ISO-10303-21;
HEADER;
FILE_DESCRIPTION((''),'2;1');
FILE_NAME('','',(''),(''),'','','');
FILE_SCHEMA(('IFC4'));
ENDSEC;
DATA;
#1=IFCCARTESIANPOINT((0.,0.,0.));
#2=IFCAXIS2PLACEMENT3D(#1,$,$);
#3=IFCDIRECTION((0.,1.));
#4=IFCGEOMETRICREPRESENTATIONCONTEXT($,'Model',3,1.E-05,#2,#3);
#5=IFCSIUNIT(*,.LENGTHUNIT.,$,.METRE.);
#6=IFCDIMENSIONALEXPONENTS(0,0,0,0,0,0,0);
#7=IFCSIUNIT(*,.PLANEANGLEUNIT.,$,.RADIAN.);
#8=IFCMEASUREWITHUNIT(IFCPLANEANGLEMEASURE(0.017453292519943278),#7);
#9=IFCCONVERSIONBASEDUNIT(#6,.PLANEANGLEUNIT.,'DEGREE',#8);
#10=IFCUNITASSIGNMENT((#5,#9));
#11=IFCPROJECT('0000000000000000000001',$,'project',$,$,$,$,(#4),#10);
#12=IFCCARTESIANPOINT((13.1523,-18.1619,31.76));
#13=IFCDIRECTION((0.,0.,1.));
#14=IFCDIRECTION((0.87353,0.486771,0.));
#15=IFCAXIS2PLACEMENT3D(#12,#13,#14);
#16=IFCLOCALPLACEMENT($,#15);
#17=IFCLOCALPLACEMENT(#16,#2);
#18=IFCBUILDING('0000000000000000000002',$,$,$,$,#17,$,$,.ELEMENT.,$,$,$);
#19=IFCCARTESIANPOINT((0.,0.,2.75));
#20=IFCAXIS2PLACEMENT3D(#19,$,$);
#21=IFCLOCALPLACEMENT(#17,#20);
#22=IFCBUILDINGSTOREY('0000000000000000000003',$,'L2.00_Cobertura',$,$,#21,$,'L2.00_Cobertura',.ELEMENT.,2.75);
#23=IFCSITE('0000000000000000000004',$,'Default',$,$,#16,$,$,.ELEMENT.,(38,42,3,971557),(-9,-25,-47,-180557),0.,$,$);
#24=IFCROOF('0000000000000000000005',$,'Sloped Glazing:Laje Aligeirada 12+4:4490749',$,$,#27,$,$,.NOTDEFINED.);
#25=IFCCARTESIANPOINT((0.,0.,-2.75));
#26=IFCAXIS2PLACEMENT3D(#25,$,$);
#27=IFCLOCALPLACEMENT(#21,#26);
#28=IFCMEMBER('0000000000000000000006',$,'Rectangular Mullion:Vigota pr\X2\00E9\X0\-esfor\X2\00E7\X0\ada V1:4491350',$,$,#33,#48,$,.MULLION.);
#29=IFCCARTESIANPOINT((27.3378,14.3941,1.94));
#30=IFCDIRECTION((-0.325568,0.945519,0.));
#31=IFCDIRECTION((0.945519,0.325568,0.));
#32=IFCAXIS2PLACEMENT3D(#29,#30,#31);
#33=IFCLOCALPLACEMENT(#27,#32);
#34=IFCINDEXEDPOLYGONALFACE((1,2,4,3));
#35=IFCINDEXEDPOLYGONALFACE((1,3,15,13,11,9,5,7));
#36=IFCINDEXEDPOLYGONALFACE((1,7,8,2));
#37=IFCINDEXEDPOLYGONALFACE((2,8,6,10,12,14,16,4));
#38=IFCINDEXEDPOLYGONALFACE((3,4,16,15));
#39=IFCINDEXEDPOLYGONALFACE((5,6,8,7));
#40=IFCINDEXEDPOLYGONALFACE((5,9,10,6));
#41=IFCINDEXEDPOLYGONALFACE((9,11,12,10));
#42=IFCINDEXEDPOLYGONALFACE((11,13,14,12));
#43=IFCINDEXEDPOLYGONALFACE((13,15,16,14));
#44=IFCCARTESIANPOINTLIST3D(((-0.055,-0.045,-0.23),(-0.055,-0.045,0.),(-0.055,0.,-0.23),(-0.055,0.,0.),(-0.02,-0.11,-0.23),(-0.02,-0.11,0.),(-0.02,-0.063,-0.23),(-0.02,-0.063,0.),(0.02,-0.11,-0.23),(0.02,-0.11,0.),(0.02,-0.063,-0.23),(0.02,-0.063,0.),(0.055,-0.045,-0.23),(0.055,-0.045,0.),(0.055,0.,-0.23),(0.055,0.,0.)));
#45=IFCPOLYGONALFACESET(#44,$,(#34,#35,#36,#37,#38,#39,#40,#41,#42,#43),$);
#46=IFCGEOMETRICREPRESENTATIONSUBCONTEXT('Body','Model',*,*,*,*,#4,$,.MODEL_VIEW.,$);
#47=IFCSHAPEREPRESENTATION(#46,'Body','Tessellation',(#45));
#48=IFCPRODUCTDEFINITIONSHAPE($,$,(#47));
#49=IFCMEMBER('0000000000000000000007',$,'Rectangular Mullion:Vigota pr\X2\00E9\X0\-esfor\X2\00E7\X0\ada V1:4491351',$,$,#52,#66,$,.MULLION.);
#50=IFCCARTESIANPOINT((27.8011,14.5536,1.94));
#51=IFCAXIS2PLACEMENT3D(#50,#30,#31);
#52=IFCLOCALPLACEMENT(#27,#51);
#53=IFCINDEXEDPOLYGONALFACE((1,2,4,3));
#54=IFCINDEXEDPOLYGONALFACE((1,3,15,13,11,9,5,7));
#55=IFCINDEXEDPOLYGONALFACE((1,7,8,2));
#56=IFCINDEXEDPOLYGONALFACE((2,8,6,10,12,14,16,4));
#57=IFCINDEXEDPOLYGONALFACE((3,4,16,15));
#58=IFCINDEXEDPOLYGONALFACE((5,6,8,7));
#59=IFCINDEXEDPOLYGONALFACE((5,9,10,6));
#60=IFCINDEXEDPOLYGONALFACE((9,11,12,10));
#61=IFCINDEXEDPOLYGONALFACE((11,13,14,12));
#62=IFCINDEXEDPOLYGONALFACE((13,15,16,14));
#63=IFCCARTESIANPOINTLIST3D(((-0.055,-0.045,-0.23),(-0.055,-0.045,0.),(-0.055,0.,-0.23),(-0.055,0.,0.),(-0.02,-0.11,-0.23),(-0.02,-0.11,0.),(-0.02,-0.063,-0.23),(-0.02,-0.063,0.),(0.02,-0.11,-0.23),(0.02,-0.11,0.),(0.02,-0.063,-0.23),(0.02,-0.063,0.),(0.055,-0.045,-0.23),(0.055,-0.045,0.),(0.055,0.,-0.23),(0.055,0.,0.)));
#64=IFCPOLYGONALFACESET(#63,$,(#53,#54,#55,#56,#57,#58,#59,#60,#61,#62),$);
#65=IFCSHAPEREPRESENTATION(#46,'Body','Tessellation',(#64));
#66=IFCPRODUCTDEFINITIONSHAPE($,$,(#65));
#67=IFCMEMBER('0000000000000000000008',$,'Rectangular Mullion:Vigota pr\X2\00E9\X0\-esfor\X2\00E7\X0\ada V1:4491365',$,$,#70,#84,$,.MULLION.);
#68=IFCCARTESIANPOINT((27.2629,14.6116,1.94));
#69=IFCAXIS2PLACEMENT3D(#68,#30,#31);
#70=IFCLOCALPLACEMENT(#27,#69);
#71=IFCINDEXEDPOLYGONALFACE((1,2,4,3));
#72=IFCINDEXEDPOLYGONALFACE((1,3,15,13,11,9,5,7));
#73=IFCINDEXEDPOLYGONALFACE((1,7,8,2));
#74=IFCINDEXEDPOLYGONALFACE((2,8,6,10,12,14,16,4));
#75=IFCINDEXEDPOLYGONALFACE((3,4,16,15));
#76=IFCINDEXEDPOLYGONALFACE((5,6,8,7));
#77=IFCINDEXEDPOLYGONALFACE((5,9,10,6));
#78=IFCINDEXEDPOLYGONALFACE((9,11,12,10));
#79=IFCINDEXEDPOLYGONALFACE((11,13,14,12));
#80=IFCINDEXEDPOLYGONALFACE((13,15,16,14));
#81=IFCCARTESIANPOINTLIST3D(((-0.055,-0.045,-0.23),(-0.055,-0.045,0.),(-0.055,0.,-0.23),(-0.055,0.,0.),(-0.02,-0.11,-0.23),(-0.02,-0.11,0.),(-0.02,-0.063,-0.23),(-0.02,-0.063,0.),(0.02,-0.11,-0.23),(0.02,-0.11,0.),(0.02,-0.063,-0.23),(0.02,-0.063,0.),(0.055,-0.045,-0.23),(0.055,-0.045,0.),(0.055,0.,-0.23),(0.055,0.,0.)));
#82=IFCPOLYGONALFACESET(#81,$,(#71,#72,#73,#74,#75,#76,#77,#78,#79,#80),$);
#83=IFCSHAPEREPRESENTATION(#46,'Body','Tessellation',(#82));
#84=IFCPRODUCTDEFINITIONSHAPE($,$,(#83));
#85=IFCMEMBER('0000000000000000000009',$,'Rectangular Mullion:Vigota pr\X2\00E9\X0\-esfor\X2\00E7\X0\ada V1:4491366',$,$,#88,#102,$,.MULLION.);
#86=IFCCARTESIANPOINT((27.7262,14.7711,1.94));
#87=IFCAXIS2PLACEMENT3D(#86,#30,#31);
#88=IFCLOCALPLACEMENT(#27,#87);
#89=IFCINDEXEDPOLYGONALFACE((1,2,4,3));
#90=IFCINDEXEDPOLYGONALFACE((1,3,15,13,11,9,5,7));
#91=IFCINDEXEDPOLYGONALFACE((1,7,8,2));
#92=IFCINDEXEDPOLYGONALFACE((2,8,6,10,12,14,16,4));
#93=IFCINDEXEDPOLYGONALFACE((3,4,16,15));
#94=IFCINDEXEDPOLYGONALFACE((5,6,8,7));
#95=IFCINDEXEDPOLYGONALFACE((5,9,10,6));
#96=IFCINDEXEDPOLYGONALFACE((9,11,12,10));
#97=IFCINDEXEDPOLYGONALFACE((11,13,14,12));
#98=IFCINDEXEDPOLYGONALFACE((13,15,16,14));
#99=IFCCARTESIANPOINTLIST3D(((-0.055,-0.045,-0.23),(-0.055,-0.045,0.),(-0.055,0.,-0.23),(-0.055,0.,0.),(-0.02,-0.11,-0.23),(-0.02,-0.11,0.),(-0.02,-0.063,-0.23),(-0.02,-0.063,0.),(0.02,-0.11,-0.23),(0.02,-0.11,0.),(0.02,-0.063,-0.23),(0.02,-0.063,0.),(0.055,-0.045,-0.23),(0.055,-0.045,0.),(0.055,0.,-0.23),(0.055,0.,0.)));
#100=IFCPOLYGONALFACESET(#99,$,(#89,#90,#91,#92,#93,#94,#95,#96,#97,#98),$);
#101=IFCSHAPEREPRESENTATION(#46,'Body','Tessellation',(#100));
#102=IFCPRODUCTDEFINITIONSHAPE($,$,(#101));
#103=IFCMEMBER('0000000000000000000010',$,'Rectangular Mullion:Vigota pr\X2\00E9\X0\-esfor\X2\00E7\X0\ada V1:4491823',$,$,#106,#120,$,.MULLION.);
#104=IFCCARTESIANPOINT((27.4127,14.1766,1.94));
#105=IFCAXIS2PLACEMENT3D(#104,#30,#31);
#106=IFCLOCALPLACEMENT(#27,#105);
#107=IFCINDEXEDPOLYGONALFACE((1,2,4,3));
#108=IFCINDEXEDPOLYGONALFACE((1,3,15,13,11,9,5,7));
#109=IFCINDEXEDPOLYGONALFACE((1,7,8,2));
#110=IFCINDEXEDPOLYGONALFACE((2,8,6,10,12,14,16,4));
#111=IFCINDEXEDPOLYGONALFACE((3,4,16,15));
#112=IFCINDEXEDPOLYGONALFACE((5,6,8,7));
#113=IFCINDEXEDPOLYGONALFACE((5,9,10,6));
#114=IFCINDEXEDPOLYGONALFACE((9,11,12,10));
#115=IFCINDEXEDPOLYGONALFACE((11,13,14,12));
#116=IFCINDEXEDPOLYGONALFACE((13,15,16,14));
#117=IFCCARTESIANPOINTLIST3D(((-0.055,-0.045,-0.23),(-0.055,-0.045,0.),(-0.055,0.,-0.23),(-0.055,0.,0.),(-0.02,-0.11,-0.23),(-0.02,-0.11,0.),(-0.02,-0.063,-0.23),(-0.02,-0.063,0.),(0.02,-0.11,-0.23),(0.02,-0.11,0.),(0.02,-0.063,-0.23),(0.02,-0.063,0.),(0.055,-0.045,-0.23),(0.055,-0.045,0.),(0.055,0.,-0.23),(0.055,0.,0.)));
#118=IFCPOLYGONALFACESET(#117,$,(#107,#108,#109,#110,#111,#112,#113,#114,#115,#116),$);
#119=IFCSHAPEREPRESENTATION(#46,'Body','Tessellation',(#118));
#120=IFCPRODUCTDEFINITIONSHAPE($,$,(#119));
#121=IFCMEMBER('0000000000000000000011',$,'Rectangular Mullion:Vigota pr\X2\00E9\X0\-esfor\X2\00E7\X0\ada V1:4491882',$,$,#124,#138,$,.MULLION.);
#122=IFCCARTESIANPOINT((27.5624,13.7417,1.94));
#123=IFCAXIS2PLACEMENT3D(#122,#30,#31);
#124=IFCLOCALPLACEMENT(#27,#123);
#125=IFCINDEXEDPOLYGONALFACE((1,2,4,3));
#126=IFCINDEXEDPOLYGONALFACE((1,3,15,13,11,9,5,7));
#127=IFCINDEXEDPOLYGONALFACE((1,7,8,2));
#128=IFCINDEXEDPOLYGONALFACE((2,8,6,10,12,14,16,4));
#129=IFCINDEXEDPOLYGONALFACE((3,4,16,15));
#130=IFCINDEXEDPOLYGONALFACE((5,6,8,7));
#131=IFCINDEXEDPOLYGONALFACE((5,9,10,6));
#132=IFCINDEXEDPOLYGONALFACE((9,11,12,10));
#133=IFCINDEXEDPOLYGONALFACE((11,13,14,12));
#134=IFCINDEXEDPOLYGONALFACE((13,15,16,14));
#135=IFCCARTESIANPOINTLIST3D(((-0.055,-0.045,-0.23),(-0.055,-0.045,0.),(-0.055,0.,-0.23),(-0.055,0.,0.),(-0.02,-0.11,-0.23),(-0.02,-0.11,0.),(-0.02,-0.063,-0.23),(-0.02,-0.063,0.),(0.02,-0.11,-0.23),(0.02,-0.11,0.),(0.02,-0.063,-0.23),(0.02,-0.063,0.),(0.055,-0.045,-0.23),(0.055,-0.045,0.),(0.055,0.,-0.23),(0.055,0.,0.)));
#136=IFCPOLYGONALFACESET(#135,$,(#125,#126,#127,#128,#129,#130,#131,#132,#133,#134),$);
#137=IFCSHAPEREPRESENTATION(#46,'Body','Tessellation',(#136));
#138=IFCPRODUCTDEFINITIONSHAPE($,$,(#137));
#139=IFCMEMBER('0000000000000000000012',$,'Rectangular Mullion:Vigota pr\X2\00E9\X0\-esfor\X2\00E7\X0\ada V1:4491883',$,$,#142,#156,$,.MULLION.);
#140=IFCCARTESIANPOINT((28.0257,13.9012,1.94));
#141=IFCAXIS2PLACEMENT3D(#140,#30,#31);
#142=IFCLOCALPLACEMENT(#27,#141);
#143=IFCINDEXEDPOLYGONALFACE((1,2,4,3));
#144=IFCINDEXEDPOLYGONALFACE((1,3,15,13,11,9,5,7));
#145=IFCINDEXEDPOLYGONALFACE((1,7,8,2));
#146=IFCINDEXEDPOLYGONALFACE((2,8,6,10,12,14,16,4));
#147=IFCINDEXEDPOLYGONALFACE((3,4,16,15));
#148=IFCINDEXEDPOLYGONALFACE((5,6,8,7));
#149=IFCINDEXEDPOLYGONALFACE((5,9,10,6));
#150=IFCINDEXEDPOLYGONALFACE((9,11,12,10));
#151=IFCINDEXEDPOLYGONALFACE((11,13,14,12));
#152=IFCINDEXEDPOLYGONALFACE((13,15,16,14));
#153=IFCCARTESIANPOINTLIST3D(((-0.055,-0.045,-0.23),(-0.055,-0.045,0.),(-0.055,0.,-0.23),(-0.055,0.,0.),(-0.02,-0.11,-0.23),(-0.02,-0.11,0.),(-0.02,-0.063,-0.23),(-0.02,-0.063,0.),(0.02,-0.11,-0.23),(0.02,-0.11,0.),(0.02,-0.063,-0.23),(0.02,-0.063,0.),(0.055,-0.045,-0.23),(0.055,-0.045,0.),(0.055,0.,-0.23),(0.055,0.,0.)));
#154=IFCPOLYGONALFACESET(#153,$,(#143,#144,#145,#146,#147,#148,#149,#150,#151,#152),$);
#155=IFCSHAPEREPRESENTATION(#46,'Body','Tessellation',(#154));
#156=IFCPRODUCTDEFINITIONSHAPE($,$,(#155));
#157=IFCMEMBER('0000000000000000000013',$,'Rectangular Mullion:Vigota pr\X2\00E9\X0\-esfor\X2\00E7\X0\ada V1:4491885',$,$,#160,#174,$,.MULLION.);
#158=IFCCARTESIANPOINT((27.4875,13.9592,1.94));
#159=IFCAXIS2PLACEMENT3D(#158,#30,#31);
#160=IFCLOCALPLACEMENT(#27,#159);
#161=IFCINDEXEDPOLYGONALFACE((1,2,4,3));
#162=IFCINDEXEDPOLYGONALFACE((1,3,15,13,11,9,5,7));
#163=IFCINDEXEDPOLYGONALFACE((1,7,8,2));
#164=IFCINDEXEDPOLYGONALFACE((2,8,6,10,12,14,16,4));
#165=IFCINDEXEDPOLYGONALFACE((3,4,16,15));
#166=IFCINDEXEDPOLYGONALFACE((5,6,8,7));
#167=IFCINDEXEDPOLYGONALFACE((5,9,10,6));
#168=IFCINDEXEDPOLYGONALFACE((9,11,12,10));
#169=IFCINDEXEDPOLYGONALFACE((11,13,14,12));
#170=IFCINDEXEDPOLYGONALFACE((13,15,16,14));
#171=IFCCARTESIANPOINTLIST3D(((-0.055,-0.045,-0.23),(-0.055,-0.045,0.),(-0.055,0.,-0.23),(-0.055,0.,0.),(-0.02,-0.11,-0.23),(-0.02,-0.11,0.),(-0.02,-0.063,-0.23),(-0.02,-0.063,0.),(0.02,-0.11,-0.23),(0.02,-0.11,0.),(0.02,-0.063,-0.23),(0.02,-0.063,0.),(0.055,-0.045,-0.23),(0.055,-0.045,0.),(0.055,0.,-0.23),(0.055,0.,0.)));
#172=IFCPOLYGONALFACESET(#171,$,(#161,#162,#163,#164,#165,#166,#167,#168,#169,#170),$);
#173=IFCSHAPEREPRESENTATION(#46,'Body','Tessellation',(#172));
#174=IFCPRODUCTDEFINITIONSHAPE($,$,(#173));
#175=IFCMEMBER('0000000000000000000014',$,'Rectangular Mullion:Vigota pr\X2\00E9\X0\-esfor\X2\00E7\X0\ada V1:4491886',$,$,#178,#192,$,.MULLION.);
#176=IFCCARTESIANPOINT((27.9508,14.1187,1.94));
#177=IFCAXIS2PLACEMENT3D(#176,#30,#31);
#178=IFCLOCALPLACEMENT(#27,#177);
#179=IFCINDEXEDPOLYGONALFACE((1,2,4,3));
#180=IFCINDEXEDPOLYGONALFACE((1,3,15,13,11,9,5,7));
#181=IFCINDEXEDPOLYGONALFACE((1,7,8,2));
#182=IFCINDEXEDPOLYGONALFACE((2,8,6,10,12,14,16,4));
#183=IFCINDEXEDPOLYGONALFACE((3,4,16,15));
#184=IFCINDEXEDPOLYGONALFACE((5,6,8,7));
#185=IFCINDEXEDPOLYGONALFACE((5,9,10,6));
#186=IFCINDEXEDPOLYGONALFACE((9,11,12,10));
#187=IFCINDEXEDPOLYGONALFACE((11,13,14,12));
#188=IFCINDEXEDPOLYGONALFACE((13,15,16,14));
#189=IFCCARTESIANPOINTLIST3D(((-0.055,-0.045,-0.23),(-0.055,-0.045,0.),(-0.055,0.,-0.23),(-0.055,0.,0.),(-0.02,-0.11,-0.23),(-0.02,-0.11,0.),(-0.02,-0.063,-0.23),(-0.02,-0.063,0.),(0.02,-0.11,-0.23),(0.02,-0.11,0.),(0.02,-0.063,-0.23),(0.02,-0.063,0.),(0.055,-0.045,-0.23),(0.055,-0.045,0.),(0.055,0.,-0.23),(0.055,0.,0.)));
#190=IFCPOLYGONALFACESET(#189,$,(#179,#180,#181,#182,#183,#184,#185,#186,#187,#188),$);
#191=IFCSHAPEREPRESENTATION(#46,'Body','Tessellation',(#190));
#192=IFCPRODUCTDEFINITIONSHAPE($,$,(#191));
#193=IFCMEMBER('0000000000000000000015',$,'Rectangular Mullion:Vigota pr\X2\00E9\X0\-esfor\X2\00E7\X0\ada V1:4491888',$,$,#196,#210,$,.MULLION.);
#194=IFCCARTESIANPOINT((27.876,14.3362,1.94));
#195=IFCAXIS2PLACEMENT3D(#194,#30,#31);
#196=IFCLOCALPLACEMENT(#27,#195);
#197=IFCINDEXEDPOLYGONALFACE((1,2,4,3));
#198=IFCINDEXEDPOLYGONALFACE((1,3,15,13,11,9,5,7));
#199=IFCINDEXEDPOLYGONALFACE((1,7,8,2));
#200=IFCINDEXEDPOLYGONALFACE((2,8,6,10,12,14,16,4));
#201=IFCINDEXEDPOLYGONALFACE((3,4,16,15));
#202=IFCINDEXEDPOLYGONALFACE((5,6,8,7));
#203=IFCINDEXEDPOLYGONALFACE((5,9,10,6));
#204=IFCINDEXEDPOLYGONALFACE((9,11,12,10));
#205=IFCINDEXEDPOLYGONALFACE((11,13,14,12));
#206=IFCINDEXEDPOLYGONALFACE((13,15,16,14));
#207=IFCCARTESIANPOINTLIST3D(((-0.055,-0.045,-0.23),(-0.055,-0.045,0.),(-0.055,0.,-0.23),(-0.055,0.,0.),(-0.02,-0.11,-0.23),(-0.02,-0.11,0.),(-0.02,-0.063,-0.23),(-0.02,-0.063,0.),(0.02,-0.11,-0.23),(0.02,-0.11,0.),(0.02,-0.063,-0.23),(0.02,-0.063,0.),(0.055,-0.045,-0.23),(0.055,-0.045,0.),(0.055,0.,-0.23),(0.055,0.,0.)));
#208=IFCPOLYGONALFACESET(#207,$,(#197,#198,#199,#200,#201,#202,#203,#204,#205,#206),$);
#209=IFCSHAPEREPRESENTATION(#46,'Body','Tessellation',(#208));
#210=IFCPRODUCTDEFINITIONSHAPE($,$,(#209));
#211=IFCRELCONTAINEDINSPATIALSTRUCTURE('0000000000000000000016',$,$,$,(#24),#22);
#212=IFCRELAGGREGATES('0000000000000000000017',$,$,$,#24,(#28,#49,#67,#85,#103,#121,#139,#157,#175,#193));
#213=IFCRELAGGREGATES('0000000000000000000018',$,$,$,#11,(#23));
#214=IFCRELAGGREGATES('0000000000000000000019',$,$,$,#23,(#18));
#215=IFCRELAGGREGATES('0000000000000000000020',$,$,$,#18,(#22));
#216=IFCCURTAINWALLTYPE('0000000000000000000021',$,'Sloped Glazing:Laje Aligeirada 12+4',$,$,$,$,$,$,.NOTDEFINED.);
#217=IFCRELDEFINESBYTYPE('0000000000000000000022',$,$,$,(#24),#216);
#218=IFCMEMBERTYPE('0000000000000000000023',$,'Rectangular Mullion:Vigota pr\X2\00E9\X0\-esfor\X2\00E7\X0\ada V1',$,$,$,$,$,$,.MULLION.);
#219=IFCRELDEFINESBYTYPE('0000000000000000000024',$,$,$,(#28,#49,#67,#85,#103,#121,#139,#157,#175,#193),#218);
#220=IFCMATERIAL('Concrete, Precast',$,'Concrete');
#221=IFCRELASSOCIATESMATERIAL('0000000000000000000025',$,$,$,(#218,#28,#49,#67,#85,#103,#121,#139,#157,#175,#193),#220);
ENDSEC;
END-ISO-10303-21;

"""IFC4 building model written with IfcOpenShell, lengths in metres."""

from ifc_helpers import new_model, entity, si_unit, converted_unit, direction, frame, origin, place, context, subcontext, project, spatial, indexed_curve, outline, extrude, source, transform, mapped, material, type_object, type_shapes, element, aggregate, save


model = new_model("IFC4")

# Units and contexts
model_context = context("Model", 3, precision=1e-05, world=origin(), true_north=direction((0.0, 1.0)))
body_context = subcontext(model_context, "Body", "Model", "MODEL_VIEW")
ifc_project = project(units=[si_unit("LENGTHUNIT", "METRE"), converted_unit("PLANEANGLEUNIT", "DEGREE", entity("IfcPlaneAngleMeasure", 0.017453292519943278), si_unit("PLANEANGLEUNIT", "RADIAN"), dimensions=[0, 0, 0, 0, 0, 0, 0])], contexts=[model_context])

# Site, building, storey
site_placement = place(None, frame((13.1523, -18.1619, 31.76), z_axis=(0.0, 0.0, 1.0), x_axis=(0.87353, 0.486771, 0.0)))
site = spatial("IfcSite", under=ifc_project, at=site_placement, Name="Default", CompositionType="ELEMENT", RefLatitude=(38, 42, 3, 971557), RefLongitude=(-9, -25, -47, -180557), RefElevation=0.0)
building_placement = place(site_placement, origin())
building = spatial("IfcBuilding", under=site, at=building_placement, CompositionType="ELEMENT")
storey_placement = place(building_placement, frame((0.0, 0.0, 2.75)))
storey = spatial("IfcBuildingStorey", under=building, at=storey_placement, Name="L2.00_Cobertura", LongName="L2.00_Cobertura", CompositionType="ELEMENT", Elevation=2.75)

# Roof, members
curtain_wall_type = type_object("IfcCurtainWallType", Name="Sloped Glazing:Laje Aligeirada 12+4", PredefinedType="NOTDEFINED")
roof_placement = place(storey_placement, frame((0.0, 0.0, -2.75)))
roof = element("IfcRoof", 1, at=roof_placement, inside=storey, type_object=curtain_wall_type, Name="Sloped Glazing:Laje Aligeirada 12+4:4490749", PredefinedType="NOTDEFINED")
ifc_material_1 = material(Name="Concrete, Precast", Category="Concrete")
member_type_1 = type_object("IfcMemberType", Name="Rectangular Mullion:Vigota pré-esforçada V1", PredefinedType="MULLION", material=ifc_material_1)
shared_shape_1 = source(origin(), body_context, "Body", "SweptSolid", [
    extrude(outline(indexed_curve([(-0.055, -0.0545), (0.055, -0.0545), (0.055, -0.0095), (0.02, 0.0085), (0.02, 0.0555), (-0.02, 0.0555), (-0.02, 0.0085), (-0.055, -0.0095), (-0.055, -0.0545)], self_intersect=False)), frame((0.0, -0.0545, -0.23), z_axis=(0.0, 0.0, 1.0), x_axis=(-1.0, 0.0, 0.0)), (0.0, 0.0, 1.0), 0.23),
])
type_shapes(member_type_1, [shared_shape_1])
member_1_placement = place(roof_placement, frame((27.3378, 14.3941, 1.94), z_axis=(-0.325568, 0.945519, 0.0), x_axis=(0.945519, 0.325568, 0.0)))
member_1 = element("IfcMember", 2, at=member_1_placement, type_object=member_type_1, material=ifc_material_1, Name="Rectangular Mullion:Vigota pré-esforçada V1:4491350", PredefinedType="MULLION", context=body_context, shape_type="MappedRepresentation", body=[
    mapped(shared_shape_1, transform((0.0, 0.0, 0.0), scale=1.0)),
])
member_2_placement = place(roof_placement, frame((27.8011, 14.5536, 1.94), z_axis=(-0.325568, 0.945519, 0.0), x_axis=(0.945519, 0.325568, 0.0)))
member_2 = element("IfcMember", 3, at=member_2_placement, type_object=member_type_1, material=ifc_material_1, Name="Rectangular Mullion:Vigota pré-esforçada V1:4491351", PredefinedType="MULLION", context=body_context, shape_type="MappedRepresentation", body=[
    mapped(shared_shape_1, transform((0.0, 0.0, 0.0), scale=1.0)),
])
member_3_placement = place(roof_placement, frame((27.2629, 14.6116, 1.94), z_axis=(-0.325568, 0.945519, 0.0), x_axis=(0.945519, 0.325568, 0.0)))
member_3 = element("IfcMember", 4, at=member_3_placement, type_object=member_type_1, material=ifc_material_1, Name="Rectangular Mullion:Vigota pré-esforçada V1:4491365", PredefinedType="MULLION", context=body_context, shape_type="MappedRepresentation", body=[
    mapped(shared_shape_1, transform((0.0, 0.0, 0.0), scale=1.0)),
])
member_4_placement = place(roof_placement, frame((27.7262, 14.7711, 1.94), z_axis=(-0.325568, 0.945519, 0.0), x_axis=(0.945519, 0.325568, 0.0)))
member_4 = element("IfcMember", 5, at=member_4_placement, type_object=member_type_1, material=ifc_material_1, Name="Rectangular Mullion:Vigota pré-esforçada V1:4491366", PredefinedType="MULLION", context=body_context, shape_type="MappedRepresentation", body=[
    mapped(shared_shape_1, transform((0.0, 0.0, 0.0), scale=1.0)),
])
member_5_placement = place(roof_placement, frame((27.4127, 14.1766, 1.94), z_axis=(-0.325568, 0.945519, 0.0), x_axis=(0.945519, 0.325568, 0.0)))
member_5 = element("IfcMember", 6, at=member_5_placement, type_object=member_type_1, material=ifc_material_1, Name="Rectangular Mullion:Vigota pré-esforçada V1:4491823", PredefinedType="MULLION", context=body_context, shape_type="MappedRepresentation", body=[
    mapped(shared_shape_1, transform((0.0, 0.0, 0.0), scale=1.0)),
])
member_6_placement = place(roof_placement, frame((27.5624, 13.7417, 1.94), z_axis=(-0.325568, 0.945519, 0.0), x_axis=(0.945519, 0.325568, 0.0)))
member_6 = element("IfcMember", 7, at=member_6_placement, type_object=member_type_1, material=ifc_material_1, Name="Rectangular Mullion:Vigota pré-esforçada V1:4491882", PredefinedType="MULLION", context=body_context, shape_type="MappedRepresentation", body=[
    mapped(shared_shape_1, transform((0.0, 0.0, 0.0), scale=1.0)),
])
member_7_placement = place(roof_placement, frame((28.0257, 13.9012, 1.94), z_axis=(-0.325568, 0.945519, 0.0), x_axis=(0.945519, 0.325568, 0.0)))
member_7 = element("IfcMember", 8, at=member_7_placement, type_object=member_type_1, material=ifc_material_1, Name="Rectangular Mullion:Vigota pré-esforçada V1:4491883", PredefinedType="MULLION", context=body_context, shape_type="MappedRepresentation", body=[
    mapped(shared_shape_1, transform((0.0, 0.0, 0.0), scale=1.0)),
])
member_8_placement = place(roof_placement, frame((27.4875, 13.9592, 1.94), z_axis=(-0.325568, 0.945519, 0.0), x_axis=(0.945519, 0.325568, 0.0)))
member_8 = element("IfcMember", 9, at=member_8_placement, type_object=member_type_1, material=ifc_material_1, Name="Rectangular Mullion:Vigota pré-esforçada V1:4491885", PredefinedType="MULLION", context=body_context, shape_type="MappedRepresentation", body=[
    mapped(shared_shape_1, transform((0.0, 0.0, 0.0), scale=1.0)),
])
member_9_placement = place(roof_placement, frame((27.9508, 14.1187, 1.94), z_axis=(-0.325568, 0.945519, 0.0), x_axis=(0.945519, 0.325568, 0.0)))
member_9 = element("IfcMember", 10, at=member_9_placement, type_object=member_type_1, material=ifc_material_1, Name="Rectangular Mullion:Vigota pré-esforçada V1:4491886", PredefinedType="MULLION", context=body_context, shape_type="MappedRepresentation", body=[
    mapped(shared_shape_1, transform((0.0, 0.0, 0.0), scale=1.0)),
])
member_10_placement = place(roof_placement, frame((27.876, 14.3362, 1.94), z_axis=(-0.325568, 0.945519, 0.0), x_axis=(0.945519, 0.325568, 0.0)))
member_10 = element("IfcMember", 11, at=member_10_placement, type_object=member_type_1, material=ifc_material_1, Name="Rectangular Mullion:Vigota pré-esforçada V1:4491888", PredefinedType="MULLION", context=body_context, shape_type="MappedRepresentation", body=[
    mapped(shared_shape_1, transform((0.0, 0.0, 0.0), scale=1.0)),
])
aggregate(roof, [member_1, member_2, member_3, member_4, member_5, member_6, member_7, member_8, member_9, member_10])

save(model, "model.ifc")
